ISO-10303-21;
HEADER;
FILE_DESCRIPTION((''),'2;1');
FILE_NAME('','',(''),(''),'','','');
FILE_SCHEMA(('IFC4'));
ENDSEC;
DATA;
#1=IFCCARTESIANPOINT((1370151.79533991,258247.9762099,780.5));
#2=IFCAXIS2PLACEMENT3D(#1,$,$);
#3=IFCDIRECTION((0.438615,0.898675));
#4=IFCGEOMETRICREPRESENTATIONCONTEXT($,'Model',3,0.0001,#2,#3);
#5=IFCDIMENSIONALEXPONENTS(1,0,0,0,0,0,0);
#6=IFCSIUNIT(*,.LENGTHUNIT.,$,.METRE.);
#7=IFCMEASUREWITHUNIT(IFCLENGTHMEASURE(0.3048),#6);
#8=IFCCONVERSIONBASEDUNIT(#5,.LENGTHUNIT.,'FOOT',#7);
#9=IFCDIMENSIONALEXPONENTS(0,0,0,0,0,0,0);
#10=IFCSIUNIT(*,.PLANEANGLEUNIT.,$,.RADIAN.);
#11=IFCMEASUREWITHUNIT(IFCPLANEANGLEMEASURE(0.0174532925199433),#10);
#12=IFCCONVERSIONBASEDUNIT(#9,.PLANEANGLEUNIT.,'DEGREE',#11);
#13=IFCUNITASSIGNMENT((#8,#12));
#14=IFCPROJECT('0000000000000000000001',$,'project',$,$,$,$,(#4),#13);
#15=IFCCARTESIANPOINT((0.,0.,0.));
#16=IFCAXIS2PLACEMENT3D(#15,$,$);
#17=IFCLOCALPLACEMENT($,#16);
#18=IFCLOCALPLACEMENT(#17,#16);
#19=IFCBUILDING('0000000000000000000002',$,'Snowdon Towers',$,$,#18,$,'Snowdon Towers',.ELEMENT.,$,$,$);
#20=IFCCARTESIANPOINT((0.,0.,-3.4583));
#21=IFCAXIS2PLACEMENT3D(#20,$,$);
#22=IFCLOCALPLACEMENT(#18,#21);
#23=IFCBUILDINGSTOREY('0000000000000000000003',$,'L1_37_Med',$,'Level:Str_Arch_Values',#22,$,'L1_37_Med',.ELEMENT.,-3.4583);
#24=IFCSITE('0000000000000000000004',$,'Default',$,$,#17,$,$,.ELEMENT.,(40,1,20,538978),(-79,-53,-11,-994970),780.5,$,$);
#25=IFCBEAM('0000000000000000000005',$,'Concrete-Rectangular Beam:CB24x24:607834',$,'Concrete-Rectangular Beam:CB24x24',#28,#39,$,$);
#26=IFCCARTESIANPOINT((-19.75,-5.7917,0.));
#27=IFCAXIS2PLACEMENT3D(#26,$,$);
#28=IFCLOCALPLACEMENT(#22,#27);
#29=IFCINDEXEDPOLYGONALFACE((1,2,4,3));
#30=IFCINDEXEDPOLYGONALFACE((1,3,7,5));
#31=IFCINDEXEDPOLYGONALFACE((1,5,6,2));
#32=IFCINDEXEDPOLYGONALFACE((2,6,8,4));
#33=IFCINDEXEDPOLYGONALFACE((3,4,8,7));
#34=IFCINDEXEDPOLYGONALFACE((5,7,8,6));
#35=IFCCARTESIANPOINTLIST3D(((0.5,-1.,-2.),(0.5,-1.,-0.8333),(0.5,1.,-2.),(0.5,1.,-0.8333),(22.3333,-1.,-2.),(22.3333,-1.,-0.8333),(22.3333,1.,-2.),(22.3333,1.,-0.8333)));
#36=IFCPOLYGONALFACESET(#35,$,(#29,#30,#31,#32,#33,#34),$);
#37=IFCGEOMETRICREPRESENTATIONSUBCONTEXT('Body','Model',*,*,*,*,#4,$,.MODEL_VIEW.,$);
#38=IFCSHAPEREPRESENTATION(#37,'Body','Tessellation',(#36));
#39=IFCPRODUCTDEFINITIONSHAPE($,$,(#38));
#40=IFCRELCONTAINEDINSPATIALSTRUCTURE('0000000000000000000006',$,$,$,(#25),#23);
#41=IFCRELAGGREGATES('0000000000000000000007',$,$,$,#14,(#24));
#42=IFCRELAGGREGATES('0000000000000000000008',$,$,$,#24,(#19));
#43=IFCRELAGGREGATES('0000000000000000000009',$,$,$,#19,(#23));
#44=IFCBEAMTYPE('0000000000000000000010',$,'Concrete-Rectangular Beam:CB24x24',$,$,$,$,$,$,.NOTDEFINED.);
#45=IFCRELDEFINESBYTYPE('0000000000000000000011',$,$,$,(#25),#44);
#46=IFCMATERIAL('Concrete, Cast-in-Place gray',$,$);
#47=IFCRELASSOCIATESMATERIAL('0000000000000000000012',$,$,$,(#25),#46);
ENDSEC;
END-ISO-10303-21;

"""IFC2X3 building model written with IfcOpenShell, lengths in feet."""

from ifc_helpers import new_model, entity, si_unit, converted_unit, direction, frame, origin, origin_2d_with_axis, place, context, subcontext, project, spatial, rectangle, extrude, material, type_object, element, save


model = new_model("IFC2X3")

# Units and contexts
model_context = context("Model", 3, precision=0.0001, world=frame((1370151.79533991, 258247.9762099, 780.5)), true_north=direction((0.438615, 0.898675)))
body_context = subcontext(model_context, "Body", "Model", "MODEL_VIEW")
ifc_project = project(units=[converted_unit("LENGTHUNIT", "FOOT", entity("IfcLengthMeasure", 0.3048), si_unit("LENGTHUNIT", "METRE"), dimensions=[1, 0, 0, 0, 0, 0, 0]), converted_unit("PLANEANGLEUNIT", "DEGREE", entity("IfcPlaneAngleMeasure", 0.0174532925199433), si_unit("PLANEANGLEUNIT", "RADIAN"), dimensions=[0, 0, 0, 0, 0, 0, 0])], contexts=[model_context])

# Site, building, storey
site_placement = place(None, origin())
site = spatial("IfcSite", under=ifc_project, at=site_placement, Name="Default", CompositionType="ELEMENT", RefLatitude=(40, 1, 20, 538978), RefLongitude=(-79, -53, -11, -994970), RefElevation=780.5)
building_placement = place(site_placement, origin())
building = spatial("IfcBuilding", under=site, at=building_placement, Name="Snowdon Towers", LongName="Snowdon Towers", CompositionType="ELEMENT")
storey_placement = place(building_placement, frame((0.0, 0.0, -3.4583)))
storey = spatial("IfcBuildingStorey", under=building, at=storey_placement, Name="L1_37_Med", ObjectType="Level:Str_Arch_Values", LongName="L1_37_Med", CompositionType="ELEMENT", Elevation=-3.4583)

# Beam
ifc_material_1 = material(Name="Concrete, Cast-in-Place gray")
beam_type_1 = type_object("IfcBeamType", Name="Concrete-Rectangular Beam:CB24x24", PredefinedType="NOTDEFINED")
beam_1_placement = place(storey_placement, frame((-19.75, -5.7917, 0.0)))
element("IfcBeam", 1, at=beam_1_placement, inside=storey, type_object=beam_type_1, material=ifc_material_1, Name="Concrete-Rectangular Beam:CB24x24:607834", ObjectType="Concrete-Rectangular Beam:CB24x24", context=body_context, shape_type="SweptSolid", body=[
    extrude(rectangle(XDim=1.1667, YDim=2.0, at=origin_2d_with_axis()), frame((0.5, 0.0, -1.4167), z_axis=(1.0, 0.0, 0.0), x_axis=(0.0, 0.0, -1.0)), (0.0, 0.0, 1.0), 21.8333),
])

save(model, "model.ifc")
